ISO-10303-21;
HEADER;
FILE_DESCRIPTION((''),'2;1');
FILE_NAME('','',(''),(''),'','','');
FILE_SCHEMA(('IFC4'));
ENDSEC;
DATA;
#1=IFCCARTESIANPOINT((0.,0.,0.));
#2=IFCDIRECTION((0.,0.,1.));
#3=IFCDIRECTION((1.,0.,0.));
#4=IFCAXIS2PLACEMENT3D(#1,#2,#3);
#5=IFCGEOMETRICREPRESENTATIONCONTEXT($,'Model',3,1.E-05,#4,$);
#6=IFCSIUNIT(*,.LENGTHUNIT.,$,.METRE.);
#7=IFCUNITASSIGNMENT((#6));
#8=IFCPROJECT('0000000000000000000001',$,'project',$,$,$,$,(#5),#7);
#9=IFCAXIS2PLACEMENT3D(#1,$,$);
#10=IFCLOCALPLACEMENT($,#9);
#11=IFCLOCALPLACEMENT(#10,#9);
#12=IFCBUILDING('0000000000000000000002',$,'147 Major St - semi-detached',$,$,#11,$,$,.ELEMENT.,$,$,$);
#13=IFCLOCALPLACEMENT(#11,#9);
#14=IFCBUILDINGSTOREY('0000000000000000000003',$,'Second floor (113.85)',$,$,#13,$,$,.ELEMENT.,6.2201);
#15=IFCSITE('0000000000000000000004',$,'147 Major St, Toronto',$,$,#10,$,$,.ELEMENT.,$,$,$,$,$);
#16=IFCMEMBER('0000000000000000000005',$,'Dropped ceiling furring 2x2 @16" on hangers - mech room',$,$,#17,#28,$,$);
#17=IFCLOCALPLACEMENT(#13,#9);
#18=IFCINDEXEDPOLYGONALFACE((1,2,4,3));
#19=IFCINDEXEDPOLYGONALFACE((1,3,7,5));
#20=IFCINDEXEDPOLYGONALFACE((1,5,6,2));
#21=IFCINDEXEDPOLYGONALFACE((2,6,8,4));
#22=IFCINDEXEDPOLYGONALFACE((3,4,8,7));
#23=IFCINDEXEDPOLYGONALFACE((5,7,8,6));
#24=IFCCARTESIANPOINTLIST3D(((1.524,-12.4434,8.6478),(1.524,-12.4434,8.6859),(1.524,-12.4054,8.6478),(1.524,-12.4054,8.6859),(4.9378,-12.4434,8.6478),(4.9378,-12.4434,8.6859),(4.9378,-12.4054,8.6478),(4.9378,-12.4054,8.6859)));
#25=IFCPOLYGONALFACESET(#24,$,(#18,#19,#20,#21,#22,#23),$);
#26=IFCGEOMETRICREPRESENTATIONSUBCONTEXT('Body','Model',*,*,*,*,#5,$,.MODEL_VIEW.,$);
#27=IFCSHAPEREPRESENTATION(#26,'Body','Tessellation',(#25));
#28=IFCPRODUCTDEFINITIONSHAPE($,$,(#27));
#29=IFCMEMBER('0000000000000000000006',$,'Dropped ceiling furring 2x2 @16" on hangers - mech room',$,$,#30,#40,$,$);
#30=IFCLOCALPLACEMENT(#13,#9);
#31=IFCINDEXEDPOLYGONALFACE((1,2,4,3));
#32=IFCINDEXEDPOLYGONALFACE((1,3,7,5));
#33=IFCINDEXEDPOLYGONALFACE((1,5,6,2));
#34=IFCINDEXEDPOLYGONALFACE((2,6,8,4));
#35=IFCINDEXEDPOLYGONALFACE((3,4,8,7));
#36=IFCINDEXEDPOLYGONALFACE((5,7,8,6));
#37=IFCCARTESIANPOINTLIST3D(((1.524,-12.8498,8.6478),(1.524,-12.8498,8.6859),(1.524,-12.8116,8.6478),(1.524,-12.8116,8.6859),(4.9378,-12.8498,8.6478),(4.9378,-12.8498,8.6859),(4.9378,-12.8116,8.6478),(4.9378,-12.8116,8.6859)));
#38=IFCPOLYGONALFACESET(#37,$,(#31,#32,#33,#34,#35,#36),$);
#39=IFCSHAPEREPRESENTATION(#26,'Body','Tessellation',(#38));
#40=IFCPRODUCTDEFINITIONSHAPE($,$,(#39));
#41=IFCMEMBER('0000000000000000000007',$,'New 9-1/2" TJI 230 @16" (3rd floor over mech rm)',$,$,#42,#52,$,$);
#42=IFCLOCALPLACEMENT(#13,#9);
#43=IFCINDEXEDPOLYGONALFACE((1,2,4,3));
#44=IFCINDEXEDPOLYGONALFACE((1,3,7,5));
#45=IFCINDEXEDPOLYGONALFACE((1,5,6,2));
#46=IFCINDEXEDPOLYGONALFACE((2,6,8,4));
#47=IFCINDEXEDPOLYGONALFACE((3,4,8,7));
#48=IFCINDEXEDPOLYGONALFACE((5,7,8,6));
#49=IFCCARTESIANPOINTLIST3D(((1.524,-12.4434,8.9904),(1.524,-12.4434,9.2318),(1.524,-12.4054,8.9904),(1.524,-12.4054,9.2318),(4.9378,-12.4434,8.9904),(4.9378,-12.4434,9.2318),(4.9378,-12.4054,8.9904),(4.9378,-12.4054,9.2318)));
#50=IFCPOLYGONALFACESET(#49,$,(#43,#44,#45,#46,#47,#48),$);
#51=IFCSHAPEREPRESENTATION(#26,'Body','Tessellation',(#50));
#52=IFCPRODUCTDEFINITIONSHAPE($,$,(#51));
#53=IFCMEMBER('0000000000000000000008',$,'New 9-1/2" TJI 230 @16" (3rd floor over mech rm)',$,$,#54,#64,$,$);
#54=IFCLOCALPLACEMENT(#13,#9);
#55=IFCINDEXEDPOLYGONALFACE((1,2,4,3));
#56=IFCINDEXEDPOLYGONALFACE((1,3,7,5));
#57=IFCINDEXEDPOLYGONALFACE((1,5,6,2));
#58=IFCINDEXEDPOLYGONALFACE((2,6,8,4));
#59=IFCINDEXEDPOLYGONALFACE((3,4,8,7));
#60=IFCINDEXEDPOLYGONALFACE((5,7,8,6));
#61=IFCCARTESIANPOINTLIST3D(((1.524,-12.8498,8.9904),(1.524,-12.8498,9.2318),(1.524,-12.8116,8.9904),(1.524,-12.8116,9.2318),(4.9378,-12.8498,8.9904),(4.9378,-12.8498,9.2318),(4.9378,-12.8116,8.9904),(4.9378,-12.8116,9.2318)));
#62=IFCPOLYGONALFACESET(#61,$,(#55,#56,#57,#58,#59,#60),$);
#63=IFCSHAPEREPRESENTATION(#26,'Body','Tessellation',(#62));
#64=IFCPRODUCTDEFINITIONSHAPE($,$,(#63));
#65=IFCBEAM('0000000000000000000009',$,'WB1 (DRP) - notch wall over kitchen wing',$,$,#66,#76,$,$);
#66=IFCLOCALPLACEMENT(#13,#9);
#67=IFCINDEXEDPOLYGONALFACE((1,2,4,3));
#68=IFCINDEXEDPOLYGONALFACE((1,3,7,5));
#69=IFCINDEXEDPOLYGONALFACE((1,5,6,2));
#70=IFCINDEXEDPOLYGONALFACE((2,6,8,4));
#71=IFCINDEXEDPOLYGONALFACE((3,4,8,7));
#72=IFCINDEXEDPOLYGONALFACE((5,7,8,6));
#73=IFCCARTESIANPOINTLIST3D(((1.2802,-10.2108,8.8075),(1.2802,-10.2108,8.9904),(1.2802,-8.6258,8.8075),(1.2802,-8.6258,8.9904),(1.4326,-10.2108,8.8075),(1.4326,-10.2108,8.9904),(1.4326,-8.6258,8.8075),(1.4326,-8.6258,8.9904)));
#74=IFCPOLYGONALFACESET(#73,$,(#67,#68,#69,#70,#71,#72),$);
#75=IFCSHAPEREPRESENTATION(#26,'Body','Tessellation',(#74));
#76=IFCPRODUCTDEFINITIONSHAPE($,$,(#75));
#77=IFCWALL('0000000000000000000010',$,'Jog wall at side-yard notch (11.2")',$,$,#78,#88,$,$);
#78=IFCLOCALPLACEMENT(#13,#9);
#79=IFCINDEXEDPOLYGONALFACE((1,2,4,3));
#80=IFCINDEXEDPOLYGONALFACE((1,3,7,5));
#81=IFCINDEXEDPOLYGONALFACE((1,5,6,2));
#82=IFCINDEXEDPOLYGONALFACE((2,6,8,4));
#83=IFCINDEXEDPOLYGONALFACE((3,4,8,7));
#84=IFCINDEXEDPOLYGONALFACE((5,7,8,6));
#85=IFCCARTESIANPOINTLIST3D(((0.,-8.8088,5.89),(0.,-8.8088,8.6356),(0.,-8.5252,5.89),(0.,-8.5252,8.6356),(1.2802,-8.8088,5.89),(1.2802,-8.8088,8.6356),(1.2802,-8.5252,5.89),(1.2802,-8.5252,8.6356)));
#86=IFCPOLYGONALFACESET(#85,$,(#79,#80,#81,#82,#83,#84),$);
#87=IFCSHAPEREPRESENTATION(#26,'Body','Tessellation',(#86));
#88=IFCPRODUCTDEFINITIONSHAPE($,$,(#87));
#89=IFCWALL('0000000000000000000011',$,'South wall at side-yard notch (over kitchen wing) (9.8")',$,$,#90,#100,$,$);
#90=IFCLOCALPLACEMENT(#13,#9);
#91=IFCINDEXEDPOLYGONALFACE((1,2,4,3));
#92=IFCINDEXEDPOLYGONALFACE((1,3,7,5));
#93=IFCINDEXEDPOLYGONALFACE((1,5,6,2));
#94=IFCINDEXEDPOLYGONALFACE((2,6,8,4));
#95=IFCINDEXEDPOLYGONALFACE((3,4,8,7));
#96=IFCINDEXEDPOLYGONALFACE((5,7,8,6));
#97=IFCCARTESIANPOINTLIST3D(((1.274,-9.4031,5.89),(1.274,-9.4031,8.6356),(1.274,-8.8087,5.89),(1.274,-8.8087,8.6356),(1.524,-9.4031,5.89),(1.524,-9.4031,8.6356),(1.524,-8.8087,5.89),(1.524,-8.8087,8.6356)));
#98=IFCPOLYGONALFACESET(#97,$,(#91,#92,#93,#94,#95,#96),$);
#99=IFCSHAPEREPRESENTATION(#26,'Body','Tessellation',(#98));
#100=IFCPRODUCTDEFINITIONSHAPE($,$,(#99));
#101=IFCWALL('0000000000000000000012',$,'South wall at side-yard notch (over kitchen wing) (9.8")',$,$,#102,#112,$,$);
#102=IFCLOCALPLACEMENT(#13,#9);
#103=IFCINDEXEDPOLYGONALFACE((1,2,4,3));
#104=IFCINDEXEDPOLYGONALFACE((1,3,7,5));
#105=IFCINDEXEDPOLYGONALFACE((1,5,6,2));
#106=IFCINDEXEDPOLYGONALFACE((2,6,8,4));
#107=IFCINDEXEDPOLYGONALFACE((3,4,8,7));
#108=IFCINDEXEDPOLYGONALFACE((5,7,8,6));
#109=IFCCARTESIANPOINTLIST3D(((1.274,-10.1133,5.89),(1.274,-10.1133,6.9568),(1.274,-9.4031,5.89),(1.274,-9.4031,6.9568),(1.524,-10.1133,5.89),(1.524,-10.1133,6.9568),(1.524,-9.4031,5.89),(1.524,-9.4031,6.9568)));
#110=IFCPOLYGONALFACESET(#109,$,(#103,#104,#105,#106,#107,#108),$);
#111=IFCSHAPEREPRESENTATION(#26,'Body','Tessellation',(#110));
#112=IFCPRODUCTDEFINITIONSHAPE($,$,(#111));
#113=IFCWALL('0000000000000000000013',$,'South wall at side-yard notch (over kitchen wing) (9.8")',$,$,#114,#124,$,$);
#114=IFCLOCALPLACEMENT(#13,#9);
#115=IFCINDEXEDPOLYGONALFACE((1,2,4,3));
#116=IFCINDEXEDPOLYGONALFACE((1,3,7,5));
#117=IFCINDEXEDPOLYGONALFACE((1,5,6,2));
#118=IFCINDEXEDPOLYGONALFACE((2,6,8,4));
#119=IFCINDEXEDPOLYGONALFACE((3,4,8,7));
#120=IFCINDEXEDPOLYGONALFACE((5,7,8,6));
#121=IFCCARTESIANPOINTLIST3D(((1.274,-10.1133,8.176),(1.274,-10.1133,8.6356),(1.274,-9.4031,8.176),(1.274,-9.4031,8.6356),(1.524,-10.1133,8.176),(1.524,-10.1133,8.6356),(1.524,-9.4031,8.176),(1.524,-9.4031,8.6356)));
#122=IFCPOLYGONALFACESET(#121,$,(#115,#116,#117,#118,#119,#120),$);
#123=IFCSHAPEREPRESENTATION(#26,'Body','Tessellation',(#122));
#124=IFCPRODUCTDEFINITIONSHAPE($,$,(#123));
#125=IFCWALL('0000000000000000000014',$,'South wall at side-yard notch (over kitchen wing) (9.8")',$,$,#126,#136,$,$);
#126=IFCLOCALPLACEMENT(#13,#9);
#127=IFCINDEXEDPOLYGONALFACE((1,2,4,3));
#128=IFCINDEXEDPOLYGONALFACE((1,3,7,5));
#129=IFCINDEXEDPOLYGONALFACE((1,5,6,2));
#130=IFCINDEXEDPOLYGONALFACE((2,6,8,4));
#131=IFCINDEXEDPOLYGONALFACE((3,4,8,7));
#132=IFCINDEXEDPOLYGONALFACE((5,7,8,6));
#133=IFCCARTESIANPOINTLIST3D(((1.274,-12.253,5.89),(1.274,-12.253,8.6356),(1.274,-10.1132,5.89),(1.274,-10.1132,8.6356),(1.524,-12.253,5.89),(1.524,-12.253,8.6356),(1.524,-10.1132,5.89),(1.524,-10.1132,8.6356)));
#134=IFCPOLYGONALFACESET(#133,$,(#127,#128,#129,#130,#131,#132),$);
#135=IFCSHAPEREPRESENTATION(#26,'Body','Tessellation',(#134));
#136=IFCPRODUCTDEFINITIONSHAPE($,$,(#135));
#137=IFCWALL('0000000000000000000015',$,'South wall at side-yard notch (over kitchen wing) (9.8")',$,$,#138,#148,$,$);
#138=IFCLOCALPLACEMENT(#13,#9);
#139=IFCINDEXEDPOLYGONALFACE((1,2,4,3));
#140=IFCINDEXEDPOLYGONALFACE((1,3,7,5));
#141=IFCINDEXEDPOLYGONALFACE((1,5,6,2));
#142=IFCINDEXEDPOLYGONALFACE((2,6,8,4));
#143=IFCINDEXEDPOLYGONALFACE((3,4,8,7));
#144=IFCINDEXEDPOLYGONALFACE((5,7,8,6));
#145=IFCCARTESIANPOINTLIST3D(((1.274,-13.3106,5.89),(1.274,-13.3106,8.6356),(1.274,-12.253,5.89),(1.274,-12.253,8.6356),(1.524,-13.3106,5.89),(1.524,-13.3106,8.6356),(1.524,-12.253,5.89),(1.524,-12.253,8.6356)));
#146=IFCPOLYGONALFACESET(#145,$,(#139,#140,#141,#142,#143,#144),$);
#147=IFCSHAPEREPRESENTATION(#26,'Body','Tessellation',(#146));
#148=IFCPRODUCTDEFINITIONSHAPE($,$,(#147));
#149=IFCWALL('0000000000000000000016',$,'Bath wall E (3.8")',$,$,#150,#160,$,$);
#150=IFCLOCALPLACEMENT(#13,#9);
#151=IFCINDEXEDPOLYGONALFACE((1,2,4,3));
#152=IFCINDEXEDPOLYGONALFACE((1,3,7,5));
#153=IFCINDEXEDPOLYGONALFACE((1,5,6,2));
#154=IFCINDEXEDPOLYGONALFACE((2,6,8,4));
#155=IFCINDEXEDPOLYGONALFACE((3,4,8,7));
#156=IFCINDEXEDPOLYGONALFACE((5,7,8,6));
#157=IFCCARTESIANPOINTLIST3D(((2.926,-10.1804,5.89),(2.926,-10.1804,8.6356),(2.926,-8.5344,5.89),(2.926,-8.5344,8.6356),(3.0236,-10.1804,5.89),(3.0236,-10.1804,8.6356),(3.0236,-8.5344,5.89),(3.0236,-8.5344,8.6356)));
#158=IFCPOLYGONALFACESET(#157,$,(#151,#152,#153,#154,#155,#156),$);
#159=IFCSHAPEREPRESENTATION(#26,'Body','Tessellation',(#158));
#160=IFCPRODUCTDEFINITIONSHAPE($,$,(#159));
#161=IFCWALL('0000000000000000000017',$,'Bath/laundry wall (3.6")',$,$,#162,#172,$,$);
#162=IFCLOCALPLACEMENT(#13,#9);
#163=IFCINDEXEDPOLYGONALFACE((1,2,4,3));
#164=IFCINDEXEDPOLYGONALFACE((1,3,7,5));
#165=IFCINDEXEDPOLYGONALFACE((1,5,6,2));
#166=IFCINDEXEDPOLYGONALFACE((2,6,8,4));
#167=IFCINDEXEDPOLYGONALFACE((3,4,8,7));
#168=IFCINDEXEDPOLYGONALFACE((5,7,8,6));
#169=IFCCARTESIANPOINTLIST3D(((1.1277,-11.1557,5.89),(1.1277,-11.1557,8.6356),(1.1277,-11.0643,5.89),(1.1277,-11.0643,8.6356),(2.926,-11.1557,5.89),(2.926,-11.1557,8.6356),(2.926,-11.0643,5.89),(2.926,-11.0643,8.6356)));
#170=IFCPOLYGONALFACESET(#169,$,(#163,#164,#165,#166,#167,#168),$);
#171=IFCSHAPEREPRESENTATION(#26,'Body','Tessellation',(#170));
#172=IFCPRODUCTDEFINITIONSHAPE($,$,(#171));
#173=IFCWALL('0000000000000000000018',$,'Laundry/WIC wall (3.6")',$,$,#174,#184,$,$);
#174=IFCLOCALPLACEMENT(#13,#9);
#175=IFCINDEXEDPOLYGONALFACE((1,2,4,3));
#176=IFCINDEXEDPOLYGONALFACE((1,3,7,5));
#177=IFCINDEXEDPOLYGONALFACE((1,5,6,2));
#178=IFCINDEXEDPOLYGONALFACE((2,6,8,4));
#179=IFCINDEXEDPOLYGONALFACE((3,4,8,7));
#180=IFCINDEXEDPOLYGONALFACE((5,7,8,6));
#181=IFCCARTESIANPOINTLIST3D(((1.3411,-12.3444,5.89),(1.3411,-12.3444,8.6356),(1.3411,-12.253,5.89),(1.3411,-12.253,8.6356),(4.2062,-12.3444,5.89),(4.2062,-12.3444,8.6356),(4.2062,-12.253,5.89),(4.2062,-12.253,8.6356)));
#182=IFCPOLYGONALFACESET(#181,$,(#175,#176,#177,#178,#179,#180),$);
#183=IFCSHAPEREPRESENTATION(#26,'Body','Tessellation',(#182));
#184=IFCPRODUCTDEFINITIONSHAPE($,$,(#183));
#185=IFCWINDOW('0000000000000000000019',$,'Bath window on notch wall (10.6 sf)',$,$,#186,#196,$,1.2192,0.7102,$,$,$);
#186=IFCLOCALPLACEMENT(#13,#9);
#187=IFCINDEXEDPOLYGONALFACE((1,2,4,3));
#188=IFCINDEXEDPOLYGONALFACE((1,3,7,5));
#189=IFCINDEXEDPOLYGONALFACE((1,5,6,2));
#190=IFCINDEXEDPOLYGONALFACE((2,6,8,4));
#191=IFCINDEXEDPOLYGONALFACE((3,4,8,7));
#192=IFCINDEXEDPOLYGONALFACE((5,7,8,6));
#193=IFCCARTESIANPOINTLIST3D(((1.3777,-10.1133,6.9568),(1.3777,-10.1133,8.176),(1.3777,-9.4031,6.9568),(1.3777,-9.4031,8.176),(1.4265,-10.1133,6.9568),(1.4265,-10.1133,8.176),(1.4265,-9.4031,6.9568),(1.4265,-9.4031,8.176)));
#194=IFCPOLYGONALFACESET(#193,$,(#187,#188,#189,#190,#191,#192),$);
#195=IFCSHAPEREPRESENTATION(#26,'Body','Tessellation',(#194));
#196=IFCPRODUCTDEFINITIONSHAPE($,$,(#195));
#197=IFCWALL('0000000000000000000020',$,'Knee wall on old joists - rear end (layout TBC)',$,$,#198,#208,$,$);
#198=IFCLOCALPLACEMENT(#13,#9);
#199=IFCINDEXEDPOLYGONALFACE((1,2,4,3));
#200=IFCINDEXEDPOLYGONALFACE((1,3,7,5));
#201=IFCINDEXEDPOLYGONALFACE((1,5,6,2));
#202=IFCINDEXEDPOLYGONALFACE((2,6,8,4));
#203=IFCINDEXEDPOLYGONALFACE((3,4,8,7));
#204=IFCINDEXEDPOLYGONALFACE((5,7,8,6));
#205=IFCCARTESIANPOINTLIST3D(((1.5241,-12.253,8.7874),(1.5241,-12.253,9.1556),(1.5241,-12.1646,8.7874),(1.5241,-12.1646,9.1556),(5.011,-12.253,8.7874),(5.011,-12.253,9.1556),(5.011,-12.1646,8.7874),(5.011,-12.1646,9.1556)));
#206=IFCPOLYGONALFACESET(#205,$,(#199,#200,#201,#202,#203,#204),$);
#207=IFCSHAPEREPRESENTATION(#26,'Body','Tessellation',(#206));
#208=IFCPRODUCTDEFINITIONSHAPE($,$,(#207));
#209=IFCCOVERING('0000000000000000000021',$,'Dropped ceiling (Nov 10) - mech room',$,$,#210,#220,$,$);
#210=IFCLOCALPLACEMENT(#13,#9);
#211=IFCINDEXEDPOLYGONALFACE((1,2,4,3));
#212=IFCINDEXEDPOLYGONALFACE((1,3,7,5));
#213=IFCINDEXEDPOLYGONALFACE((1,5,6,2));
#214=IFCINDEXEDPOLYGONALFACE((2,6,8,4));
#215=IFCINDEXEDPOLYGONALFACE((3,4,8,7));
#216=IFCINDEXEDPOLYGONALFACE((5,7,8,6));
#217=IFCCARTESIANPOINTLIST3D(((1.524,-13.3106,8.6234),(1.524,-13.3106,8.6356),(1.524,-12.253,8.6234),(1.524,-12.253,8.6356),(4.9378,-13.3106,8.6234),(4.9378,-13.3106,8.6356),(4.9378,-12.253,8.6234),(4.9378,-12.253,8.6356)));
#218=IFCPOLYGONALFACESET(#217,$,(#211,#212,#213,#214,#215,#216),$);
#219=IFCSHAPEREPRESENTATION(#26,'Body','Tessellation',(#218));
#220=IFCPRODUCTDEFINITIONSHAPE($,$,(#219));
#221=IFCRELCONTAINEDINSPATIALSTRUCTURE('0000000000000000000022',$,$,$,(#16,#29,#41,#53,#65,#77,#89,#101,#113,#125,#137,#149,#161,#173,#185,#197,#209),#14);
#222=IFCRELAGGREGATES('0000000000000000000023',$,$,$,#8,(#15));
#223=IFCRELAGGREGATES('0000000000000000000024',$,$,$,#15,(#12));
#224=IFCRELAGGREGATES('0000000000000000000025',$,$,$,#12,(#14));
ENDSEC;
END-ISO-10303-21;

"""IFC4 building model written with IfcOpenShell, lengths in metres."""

from ifc_helpers import new_model, si_unit, frame, origin, origin_with_axes, place, context, subcontext, project, spatial, rectangle, extrude, element, save


model = new_model("IFC4")

# Units and contexts
model_context = context("Model", 3, precision=1e-05, world=origin_with_axes())
body_context = subcontext(model_context, "Body", "Model", "MODEL_VIEW")
ifc_project = project(units=[si_unit("LENGTHUNIT", "METRE")], contexts=[model_context])

# Site, building, storey
site_placement = place(None, origin())
site = spatial("IfcSite", under=ifc_project, at=site_placement, Name="147 Major St, Toronto", CompositionType="ELEMENT")
building_placement = place(site_placement, origin())
building = spatial("IfcBuilding", under=site, at=building_placement, Name="147 Major St - semi-detached", CompositionType="ELEMENT")
storey_placement = place(building_placement, origin())
storey = spatial("IfcBuildingStorey", under=building, at=storey_placement, Name="Second floor (113.85)", CompositionType="ELEMENT", Elevation=6.2201)

# Members
for number, where, name in (
    (1, (3.2309, -12.4244, 8.6478), "Dropped ceiling furring 2x2 @16\" on hangers - mech room"),
    (2, (3.2309, -12.8307, 8.6478), "Dropped ceiling furring 2x2 @16\" on hangers - mech room"),
):
    element("IfcMember", number, at=place(storey_placement, frame(where)), inside=storey, Name=name, context=body_context, shape_type="SweptSolid", body=[
        extrude(rectangle(XDim=3.4138, YDim=0.0381), origin_with_axes(), (0.0, 0.0, 1.0), 0.0381),
    ])
for number, where, name in (
    (3, (3.2309, -12.4244, 8.9904), "New 9-1/2\" TJI 230 @16\" (3rd floor over mech rm)"),
    (4, (3.2309, -12.8307, 8.9904), "New 9-1/2\" TJI 230 @16\" (3rd floor over mech rm)"),
):
    element("IfcMember", number, at=place(storey_placement, frame(where)), inside=storey, Name=name, context=body_context, shape_type="SweptSolid", body=[
        extrude(rectangle(XDim=3.4138, YDim=0.0381), origin_with_axes(), (0.0, 0.0, 1.0), 0.2414),
    ])

# Beam
beam_placement = place(storey_placement, frame((1.3564, -9.4183, 8.8075)))
element("IfcBeam", 5, at=beam_placement, inside=storey, Name="WB1 (DRP) - notch wall over kitchen wing", context=body_context, shape_type="SweptSolid", body=[
    extrude(rectangle(XDim=0.1524, YDim=1.585), origin_with_axes(), (0.0, 0.0, 1.0), 0.1829),
])

# Walls
wall_1_placement = place(storey_placement, frame((0.6401, -8.667, 5.89)))
element("IfcWall", 6, at=wall_1_placement, inside=storey, Name="Jog wall at side-yard notch (11.2\")", context=body_context, shape_type="SweptSolid", body=[
    extrude(rectangle(XDim=1.2802, YDim=0.2835), origin_with_axes(), (0.0, 0.0, 1.0), 2.7456),
])
wall_2_placement = place(storey_placement, frame((1.399, -9.1059, 5.89)))
element("IfcWall", 7, at=wall_2_placement, inside=storey, Name="South wall at side-yard notch (over kitchen wing) (9.8\")", context=body_context, shape_type="SweptSolid", body=[
    extrude(rectangle(XDim=0.2499, YDim=0.5944), origin_with_axes(), (0.0, 0.0, 1.0), 2.7456),
])
wall_3_placement = place(storey_placement, frame((1.399, -9.7582, 5.89)))
element("IfcWall", 8, at=wall_3_placement, inside=storey, Name="South wall at side-yard notch (over kitchen wing) (9.8\")", context=body_context, shape_type="SweptSolid", body=[
    extrude(rectangle(XDim=0.2499, YDim=0.7102), origin_with_axes(), (0.0, 0.0, 1.0), 1.0668),
])
wall_4_placement = place(storey_placement, frame((1.399, -9.7582, 8.176)))
element("IfcWall", 9, at=wall_4_placement, inside=storey, Name="South wall at side-yard notch (over kitchen wing) (9.8\")", context=body_context, shape_type="SweptSolid", body=[
    extrude(rectangle(XDim=0.2499, YDim=0.7102), origin_with_axes(), (0.0, 0.0, 1.0), 0.4596),
])
wall_5_placement = place(storey_placement, frame((1.399, -11.1831, 5.89)))
element("IfcWall", 10, at=wall_5_placement, inside=storey, Name="South wall at side-yard notch (over kitchen wing) (9.8\")", context=body_context, shape_type="SweptSolid", body=[
    extrude(rectangle(XDim=0.2499, YDim=2.1397), origin_with_axes(), (0.0, 0.0, 1.0), 2.7456),
])
wall_6_placement = place(storey_placement, frame((1.399, -12.7818, 5.89)))
element("IfcWall", 11, at=wall_6_placement, inside=storey, Name="South wall at side-yard notch (over kitchen wing) (9.8\")", context=body_context, shape_type="SweptSolid", body=[
    extrude(rectangle(XDim=0.2499, YDim=1.0577), origin_with_axes(), (0.0, 0.0, 1.0), 2.7456),
])
wall_7_placement = place(storey_placement, frame((2.9748, -9.3574, 5.89)))
element("IfcWall", 12, at=wall_7_placement, inside=storey, Name="Bath wall E (3.8\")", context=body_context, shape_type="SweptSolid", body=[
    extrude(rectangle(XDim=0.0975, YDim=1.6459), origin_with_axes(), (0.0, 0.0, 1.0), 2.7456),
])
wall_8_placement = place(storey_placement, frame((2.0269, -11.11, 5.89)))
element("IfcWall", 13, at=wall_8_placement, inside=storey, Name="Bath/laundry wall (3.6\")", context=body_context, shape_type="SweptSolid", body=[
    extrude(rectangle(XDim=1.7983, YDim=0.0914), origin_with_axes(), (0.0, 0.0, 1.0), 2.7456),
])
wall_9_placement = place(storey_placement, frame((2.7737, -12.2987, 5.89)))
element("IfcWall", 14, at=wall_9_placement, inside=storey, Name="Laundry/WIC wall (3.6\")", context=body_context, shape_type="SweptSolid", body=[
    extrude(rectangle(XDim=2.8651, YDim=0.0914), origin_with_axes(), (0.0, 0.0, 1.0), 2.7456),
])

# Window
window_placement = place(storey_placement, frame((1.4021, -9.7582, 6.9568)))
element("IfcWindow", 15, at=window_placement, inside=storey, Name="Bath window on notch wall (10.6 sf)", OverallHeight=1.2192, OverallWidth=0.7102, context=body_context, shape_type="SweptSolid", body=[
    extrude(rectangle(XDim=0.0488, YDim=0.7102), origin_with_axes(), (0.0, 0.0, 1.0), 1.2192),
])

# Wall
wall_10_placement = place(storey_placement, frame((3.2675, -12.2088, 8.7874)))
element("IfcWall", 16, at=wall_10_placement, inside=storey, Name="Knee wall on old joists - rear end (layout TBC)", context=body_context, shape_type="SweptSolid", body=[
    extrude(rectangle(XDim=3.4869, YDim=0.0884), origin_with_axes(), (0.0, 0.0, 1.0), 0.3682),
])

# Covering
for number, where, name in (
    (17, (3.2309, -12.7818, 8.6234), "Dropped ceiling (Nov 10) - mech room"),
):
    element("IfcCovering", number, at=place(storey_placement, frame(where)), inside=storey, Name=name, context=body_context, shape_type="SweptSolid", body=[
        extrude(rectangle(XDim=3.4138, YDim=1.0577), origin_with_axes(), (0.0, 0.0, 1.0), 0.0122),
    ])

save(model, "model.ifc")
